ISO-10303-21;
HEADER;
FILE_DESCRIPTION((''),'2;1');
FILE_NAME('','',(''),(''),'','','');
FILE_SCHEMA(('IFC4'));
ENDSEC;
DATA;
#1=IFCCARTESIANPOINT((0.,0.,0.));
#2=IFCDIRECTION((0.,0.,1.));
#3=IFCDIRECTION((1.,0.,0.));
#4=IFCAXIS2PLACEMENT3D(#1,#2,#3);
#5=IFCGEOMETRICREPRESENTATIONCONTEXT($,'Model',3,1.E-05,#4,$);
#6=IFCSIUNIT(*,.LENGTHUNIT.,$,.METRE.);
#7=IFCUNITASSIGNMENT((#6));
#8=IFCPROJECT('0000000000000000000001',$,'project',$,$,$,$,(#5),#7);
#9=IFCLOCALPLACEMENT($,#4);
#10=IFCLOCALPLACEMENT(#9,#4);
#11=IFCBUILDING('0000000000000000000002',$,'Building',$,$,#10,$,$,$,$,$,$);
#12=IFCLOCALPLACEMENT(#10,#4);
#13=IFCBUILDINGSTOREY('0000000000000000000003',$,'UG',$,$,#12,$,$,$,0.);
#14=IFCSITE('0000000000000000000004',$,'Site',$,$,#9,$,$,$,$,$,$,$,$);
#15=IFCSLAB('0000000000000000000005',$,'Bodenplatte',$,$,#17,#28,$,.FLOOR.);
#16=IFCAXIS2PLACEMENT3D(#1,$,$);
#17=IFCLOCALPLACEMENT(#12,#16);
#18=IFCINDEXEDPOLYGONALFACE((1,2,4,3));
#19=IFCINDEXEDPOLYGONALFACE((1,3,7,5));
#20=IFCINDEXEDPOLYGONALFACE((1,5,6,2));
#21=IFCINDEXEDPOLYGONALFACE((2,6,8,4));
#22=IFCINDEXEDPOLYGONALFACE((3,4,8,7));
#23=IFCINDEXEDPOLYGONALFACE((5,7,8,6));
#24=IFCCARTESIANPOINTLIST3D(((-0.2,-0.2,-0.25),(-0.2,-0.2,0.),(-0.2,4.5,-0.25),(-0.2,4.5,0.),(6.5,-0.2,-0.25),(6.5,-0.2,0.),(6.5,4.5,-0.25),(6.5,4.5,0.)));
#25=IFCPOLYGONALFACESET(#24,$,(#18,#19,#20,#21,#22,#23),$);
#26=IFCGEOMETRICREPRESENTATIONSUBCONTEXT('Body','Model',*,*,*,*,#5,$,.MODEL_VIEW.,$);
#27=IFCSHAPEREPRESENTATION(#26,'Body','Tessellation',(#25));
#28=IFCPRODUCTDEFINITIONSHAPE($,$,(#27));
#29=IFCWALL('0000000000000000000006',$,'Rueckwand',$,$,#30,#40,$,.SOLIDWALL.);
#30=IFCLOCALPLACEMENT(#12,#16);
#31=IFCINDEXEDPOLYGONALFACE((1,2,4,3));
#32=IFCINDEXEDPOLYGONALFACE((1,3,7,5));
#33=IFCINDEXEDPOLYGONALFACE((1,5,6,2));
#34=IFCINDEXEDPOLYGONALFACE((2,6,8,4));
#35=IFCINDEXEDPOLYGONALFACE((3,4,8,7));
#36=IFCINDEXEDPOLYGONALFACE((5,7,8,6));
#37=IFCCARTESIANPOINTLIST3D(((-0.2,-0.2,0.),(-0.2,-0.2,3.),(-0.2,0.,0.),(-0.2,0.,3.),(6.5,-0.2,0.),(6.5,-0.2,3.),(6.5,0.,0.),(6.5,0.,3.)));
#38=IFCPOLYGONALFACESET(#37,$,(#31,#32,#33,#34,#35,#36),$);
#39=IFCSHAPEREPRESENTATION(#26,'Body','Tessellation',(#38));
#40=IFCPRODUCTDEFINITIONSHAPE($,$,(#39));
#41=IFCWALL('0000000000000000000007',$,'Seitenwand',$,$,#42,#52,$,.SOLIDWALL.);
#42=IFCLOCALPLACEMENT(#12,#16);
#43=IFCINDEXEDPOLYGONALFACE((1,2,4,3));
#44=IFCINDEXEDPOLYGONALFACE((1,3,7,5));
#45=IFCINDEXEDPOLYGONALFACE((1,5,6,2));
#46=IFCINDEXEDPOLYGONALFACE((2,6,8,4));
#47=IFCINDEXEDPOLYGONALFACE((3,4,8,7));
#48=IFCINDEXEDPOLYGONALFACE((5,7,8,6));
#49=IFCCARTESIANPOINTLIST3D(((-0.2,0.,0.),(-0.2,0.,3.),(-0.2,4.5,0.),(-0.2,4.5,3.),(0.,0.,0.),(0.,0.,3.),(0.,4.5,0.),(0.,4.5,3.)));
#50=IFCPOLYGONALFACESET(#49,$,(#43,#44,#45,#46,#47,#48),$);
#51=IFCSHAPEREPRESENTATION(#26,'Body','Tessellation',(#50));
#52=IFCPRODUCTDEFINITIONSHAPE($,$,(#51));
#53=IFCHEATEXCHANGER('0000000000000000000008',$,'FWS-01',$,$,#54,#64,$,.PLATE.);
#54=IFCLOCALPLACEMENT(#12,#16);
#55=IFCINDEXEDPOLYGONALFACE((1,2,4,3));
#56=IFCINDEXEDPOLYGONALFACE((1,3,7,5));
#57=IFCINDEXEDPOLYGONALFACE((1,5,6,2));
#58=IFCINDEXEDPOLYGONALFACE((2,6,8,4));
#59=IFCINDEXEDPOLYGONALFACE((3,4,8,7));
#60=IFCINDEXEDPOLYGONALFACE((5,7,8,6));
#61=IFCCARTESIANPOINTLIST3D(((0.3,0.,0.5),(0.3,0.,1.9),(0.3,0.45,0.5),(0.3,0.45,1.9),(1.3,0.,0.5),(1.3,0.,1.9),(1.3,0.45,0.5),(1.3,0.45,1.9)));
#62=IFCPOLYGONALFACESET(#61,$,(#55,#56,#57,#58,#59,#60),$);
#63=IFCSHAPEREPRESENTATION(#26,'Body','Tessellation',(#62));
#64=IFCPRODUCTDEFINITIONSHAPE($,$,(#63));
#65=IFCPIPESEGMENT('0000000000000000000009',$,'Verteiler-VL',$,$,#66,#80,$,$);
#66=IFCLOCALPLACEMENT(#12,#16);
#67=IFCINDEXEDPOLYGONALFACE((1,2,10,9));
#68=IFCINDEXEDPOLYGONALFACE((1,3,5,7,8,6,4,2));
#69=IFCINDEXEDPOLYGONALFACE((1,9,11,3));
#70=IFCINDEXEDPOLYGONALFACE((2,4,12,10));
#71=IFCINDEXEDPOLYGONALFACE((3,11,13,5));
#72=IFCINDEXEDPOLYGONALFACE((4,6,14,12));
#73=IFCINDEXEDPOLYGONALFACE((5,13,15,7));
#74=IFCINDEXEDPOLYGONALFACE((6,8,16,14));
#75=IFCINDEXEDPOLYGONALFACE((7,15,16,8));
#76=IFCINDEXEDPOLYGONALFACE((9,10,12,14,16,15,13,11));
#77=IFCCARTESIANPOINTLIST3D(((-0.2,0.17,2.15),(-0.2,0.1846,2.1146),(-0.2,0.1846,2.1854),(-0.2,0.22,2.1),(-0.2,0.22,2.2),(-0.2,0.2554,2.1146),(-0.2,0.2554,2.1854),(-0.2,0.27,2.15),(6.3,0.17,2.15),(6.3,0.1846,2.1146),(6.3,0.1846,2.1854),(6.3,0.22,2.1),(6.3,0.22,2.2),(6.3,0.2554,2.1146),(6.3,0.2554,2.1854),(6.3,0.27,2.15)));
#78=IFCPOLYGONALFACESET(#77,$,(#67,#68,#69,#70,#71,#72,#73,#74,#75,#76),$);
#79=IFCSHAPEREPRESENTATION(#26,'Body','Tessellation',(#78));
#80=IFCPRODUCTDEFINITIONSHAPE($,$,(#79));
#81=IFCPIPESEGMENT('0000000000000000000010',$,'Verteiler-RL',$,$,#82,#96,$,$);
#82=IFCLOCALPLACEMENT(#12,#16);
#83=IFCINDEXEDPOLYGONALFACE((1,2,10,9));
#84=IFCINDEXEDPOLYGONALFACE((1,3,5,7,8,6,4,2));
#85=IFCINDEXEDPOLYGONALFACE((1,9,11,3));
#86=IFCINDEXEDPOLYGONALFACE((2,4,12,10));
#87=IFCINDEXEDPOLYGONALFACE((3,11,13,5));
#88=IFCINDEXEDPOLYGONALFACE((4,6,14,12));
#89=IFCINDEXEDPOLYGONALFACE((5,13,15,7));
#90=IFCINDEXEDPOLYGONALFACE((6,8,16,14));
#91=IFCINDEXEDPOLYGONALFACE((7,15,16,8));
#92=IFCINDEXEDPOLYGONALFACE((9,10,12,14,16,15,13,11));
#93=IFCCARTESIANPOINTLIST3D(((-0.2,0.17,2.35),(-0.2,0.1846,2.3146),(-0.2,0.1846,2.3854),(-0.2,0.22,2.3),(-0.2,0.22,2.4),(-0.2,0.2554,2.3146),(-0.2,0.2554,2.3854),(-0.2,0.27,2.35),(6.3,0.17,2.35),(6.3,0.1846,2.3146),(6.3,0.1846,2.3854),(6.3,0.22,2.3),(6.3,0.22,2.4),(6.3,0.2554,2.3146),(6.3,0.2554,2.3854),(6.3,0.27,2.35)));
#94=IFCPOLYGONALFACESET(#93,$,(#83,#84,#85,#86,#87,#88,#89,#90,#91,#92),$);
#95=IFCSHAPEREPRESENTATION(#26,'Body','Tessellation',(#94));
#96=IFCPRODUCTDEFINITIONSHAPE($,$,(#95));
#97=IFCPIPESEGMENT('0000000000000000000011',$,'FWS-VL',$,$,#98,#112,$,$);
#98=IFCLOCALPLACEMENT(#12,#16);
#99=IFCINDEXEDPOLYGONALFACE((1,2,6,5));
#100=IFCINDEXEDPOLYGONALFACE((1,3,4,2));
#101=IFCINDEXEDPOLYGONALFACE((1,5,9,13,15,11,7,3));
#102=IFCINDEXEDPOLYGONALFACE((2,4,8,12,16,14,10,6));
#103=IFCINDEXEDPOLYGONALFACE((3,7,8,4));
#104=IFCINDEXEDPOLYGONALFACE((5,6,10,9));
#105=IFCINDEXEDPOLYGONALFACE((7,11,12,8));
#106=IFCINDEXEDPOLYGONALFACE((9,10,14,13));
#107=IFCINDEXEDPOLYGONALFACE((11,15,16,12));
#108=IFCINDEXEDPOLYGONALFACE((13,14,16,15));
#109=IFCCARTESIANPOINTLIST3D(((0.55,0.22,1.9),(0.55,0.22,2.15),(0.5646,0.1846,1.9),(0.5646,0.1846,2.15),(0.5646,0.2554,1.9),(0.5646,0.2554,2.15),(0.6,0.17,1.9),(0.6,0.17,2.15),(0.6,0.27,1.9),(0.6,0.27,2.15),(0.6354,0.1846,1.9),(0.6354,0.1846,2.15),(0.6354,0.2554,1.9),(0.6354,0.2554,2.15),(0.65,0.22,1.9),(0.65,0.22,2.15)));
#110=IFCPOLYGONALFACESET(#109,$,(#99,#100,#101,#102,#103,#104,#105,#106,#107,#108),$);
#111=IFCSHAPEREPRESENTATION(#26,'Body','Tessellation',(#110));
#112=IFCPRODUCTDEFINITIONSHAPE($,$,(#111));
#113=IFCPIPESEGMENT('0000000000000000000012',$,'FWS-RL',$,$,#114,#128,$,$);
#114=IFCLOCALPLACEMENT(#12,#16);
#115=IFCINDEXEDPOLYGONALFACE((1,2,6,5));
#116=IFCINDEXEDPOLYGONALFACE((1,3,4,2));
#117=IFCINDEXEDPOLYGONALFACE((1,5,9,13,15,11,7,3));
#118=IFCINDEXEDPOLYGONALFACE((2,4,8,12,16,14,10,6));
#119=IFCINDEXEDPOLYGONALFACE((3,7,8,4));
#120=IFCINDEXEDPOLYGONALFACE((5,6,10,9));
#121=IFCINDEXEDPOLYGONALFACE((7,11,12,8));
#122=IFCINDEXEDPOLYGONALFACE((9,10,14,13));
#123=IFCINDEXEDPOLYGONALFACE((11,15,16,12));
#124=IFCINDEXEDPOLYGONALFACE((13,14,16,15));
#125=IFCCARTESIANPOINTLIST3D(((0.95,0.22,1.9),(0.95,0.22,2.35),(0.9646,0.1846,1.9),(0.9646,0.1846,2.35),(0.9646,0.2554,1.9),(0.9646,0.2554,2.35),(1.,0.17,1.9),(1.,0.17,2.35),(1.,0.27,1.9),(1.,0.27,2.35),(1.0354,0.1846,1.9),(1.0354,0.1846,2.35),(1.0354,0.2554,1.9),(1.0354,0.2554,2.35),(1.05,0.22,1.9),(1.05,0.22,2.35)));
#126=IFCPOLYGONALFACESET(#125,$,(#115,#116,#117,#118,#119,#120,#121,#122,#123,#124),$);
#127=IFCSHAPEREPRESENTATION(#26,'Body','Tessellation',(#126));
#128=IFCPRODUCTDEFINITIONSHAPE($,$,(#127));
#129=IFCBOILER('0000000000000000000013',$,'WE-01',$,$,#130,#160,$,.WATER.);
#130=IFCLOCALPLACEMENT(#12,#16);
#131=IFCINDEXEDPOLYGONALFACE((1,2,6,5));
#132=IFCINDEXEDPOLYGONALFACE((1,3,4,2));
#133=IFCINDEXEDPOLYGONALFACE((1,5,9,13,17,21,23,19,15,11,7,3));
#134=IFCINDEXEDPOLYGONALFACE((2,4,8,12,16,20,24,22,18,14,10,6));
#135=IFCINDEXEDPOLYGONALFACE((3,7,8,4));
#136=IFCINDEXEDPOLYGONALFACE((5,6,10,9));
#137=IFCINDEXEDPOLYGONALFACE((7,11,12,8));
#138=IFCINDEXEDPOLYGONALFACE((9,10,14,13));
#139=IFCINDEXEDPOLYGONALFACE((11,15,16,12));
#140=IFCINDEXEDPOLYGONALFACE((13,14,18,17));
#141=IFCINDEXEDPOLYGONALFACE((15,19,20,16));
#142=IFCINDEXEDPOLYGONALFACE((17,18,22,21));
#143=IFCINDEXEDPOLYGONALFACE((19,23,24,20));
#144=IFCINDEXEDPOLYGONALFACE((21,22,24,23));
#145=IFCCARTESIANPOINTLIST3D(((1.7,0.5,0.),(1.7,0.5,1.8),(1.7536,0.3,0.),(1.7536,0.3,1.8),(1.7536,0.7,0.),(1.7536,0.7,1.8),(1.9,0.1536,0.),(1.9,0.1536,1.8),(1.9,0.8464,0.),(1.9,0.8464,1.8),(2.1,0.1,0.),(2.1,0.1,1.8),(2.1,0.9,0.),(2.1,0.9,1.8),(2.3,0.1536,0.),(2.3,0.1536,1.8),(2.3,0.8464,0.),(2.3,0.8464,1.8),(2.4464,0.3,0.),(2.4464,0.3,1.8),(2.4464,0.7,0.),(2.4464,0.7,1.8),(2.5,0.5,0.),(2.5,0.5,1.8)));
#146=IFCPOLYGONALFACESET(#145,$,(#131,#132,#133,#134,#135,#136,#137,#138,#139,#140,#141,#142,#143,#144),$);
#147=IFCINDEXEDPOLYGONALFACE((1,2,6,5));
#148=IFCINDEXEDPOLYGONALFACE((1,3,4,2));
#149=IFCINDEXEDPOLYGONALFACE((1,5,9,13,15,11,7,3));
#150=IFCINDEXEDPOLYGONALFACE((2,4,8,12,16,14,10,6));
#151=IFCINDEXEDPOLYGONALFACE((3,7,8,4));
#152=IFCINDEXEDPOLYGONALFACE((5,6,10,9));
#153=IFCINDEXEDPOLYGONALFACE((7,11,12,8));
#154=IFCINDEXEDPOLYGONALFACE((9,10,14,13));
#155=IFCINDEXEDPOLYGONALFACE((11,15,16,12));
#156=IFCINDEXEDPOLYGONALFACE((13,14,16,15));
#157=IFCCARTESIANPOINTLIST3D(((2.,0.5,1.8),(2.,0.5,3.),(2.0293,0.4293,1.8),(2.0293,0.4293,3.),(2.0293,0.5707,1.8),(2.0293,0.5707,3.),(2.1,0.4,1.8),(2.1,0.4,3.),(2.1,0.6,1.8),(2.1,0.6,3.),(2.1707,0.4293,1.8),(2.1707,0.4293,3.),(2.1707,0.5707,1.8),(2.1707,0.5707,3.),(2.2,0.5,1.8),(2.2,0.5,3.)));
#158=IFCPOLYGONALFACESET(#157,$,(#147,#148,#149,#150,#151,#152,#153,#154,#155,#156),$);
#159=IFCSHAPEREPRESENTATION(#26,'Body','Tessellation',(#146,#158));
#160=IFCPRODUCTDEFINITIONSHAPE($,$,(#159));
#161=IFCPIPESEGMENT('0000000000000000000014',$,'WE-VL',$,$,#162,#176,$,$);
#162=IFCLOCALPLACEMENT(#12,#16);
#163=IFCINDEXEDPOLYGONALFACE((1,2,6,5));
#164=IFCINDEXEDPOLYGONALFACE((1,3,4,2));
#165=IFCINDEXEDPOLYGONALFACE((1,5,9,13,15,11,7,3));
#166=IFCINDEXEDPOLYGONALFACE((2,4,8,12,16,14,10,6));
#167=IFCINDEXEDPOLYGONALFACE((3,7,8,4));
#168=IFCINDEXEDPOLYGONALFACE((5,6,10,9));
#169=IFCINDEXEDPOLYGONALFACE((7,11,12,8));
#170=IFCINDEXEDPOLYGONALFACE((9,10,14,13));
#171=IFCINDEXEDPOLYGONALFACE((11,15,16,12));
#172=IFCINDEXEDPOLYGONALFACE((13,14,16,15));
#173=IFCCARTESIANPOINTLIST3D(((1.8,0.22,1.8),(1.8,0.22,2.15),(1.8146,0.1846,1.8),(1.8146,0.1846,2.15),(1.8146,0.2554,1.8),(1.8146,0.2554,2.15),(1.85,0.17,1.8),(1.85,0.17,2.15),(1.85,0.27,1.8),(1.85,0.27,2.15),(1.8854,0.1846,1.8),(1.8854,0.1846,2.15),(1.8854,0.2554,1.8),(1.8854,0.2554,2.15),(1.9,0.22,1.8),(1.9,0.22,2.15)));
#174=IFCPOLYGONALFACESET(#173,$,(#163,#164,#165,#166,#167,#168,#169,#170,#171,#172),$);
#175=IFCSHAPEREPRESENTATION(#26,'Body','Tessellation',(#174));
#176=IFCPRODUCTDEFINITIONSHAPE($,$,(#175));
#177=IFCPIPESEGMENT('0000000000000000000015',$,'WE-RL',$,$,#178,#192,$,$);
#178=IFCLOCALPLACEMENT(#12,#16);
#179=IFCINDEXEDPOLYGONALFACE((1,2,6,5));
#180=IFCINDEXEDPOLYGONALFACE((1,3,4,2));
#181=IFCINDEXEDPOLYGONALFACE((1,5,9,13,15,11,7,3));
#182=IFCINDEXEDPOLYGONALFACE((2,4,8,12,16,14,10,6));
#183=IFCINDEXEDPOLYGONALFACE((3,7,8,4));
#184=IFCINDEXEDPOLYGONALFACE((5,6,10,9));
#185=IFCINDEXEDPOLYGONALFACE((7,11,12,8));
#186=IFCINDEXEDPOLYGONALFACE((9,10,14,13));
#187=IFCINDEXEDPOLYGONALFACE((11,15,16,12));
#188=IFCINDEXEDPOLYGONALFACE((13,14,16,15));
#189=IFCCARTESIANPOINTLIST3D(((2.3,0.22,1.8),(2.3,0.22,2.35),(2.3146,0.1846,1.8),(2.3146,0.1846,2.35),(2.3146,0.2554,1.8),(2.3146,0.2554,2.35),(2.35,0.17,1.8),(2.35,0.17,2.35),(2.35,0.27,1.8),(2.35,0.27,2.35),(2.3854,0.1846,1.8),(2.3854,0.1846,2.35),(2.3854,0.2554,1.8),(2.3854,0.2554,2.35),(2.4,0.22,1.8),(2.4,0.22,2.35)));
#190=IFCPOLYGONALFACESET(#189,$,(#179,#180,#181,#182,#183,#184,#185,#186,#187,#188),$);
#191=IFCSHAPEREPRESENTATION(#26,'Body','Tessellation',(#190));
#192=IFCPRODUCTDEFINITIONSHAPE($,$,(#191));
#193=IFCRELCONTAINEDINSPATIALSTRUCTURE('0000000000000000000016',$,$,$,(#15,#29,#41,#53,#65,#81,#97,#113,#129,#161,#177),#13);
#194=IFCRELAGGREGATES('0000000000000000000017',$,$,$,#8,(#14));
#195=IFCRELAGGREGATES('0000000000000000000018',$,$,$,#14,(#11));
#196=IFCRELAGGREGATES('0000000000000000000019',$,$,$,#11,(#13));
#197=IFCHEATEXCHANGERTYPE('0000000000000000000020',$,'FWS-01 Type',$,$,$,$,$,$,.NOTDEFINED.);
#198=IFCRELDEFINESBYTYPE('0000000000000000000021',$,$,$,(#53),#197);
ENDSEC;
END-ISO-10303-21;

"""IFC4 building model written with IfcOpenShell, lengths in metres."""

from ifc_helpers import new_model, si_unit, frame, origin_with_axes, place, context, subcontext, project, spatial, polyline, outline, extrude, type_object, element, save


model = new_model("IFC4")

# Units and contexts
model_context = context("Model", 3, precision=1e-05, world=origin_with_axes())
body_context = subcontext(model_context, "Body", "Model", "MODEL_VIEW")
ifc_project = project(units=[si_unit("LENGTHUNIT", "METRE")], contexts=[model_context])

# Site, building, storey
site_placement = place(None, origin_with_axes())
site = spatial("IfcSite", under=ifc_project, at=site_placement, Name="Site")
building_placement = place(site_placement, origin_with_axes())
building = spatial("IfcBuilding", under=site, at=building_placement, Name="Building")
storey_placement = place(building_placement, origin_with_axes())
storey = spatial("IfcBuildingStorey", under=building, at=storey_placement, Name="UG", Elevation=0.0)

# Slab
slab_placement = place(storey_placement, frame((0.0, 0.0, -0.25), z_axis=(0.0, 0.0, 1.0), x_axis=(1.0, 0.0, 0.0)))
element("IfcSlab", 1, at=slab_placement, inside=storey, Name="Bodenplatte", PredefinedType="FLOOR", context=body_context, shape_type="SweptSolid", body=[
    extrude(outline(polyline([(-0.2, -0.2, 0.0), (6.5, -0.2, 0.0), (6.5, 4.5, 0.0), (-0.2, 4.5, 0.0), (-0.2, -0.2, 0.0)])), origin_with_axes(), (0.0, 0.0, 1.0), 0.25),
])

# Walls
wall_1_placement = place(storey_placement, frame((-0.2, -0.2, 0.0), z_axis=(0.0, 0.0, 1.0), x_axis=(1.0, 0.0, 0.0)))
element("IfcWall", 2, at=wall_1_placement, inside=storey, Name="Rueckwand", PredefinedType="SOLIDWALL", context=body_context, shape_type="SweptSolid", body=[
    extrude(outline(polyline([(0.0, 0.0, 0.0), (6.7, 0.0, 0.0), (6.7, 0.2, 0.0), (0.0, 0.2, 0.0), (0.0, 0.0, 0.0)])), origin_with_axes(), (0.0, 0.0, 1.0), 3.0),
])
wall_2_placement = place(storey_placement, frame((0.0, 0.0, 0.0), z_axis=(0.0, 0.0, 1.0), x_axis=(0.0, 1.0, 0.0)))
element("IfcWall", 3, at=wall_2_placement, inside=storey, Name="Seitenwand", PredefinedType="SOLIDWALL", context=body_context, shape_type="SweptSolid", body=[
    extrude(outline(polyline([(0.0, 0.0, 0.0), (4.5, 0.0, 0.0), (4.5, 0.2, 0.0), (0.0, 0.2, 0.0), (0.0, 0.0, 0.0)])), origin_with_axes(), (0.0, 0.0, 1.0), 3.0),
])

# Heat exchanger
heat_exchanger_type = type_object("IfcHeatExchangerType", Name="FWS-01 Type", PredefinedType="NOTDEFINED")
heat_exchanger_placement = place(storey_placement, origin_with_axes())
element("IfcHeatExchanger", 4, at=heat_exchanger_placement, inside=storey, type_object=heat_exchanger_type, Name="FWS-01", PredefinedType="PLATE", context=body_context, shape_type="SweptSolid", body=[
    extrude(outline(polyline([(0.3, 0.0, 0.0), (1.3, 0.0, 0.0), (1.3, 0.45, 0.0), (0.3, 0.45, 0.0), (0.3, 0.0, 0.0)])), frame((0.0, 0.0, 0.5), z_axis=(0.0, 0.0, 1.0), x_axis=(1.0, 0.0, 0.0)), (0.0, 0.0, 1.0), 1.4),
])

# Pipe segments
pipe_segment_1_placement = place(storey_placement, origin_with_axes())
element("IfcPipeSegment", 5, at=pipe_segment_1_placement, inside=storey, Name="Verteiler-VL", context=body_context, shape_type="SweptSolid", body=[
    extrude(outline(polyline([(0.05, 0.0, 0.0), (0.0354, 0.0354, 0.0), (0.0, 0.05, 0.0), (-0.0354, 0.0354, 0.0), (-0.05, 0.0, 0.0), (-0.0354, -0.0354, 0.0), (0.0, -0.05, 0.0), (0.0354, -0.0354, 0.0), (0.05, 0.0, 0.0)])), frame((-0.2, 0.22, 2.15), z_axis=(1.0, 0.0, 0.0), x_axis=(0.0, 1.0, 0.0)), (0.0, 0.0, 1.0), 6.5),
])
pipe_segment_2_placement = place(storey_placement, origin_with_axes())
element("IfcPipeSegment", 6, at=pipe_segment_2_placement, inside=storey, Name="Verteiler-RL", context=body_context, shape_type="SweptSolid", body=[
    extrude(outline(polyline([(0.05, 0.0, 0.0), (0.0354, 0.0354, 0.0), (0.0, 0.05, 0.0), (-0.0354, 0.0354, 0.0), (-0.05, 0.0, 0.0), (-0.0354, -0.0354, 0.0), (0.0, -0.05, 0.0), (0.0354, -0.0354, 0.0), (0.05, 0.0, 0.0)])), frame((-0.2, 0.22, 2.35), z_axis=(1.0, 0.0, 0.0), x_axis=(0.0, 1.0, 0.0)), (0.0, 0.0, 1.0), 6.5),
])
pipe_segment_3_placement = place(storey_placement, origin_with_axes())
element("IfcPipeSegment", 7, at=pipe_segment_3_placement, inside=storey, Name="FWS-VL", context=body_context, shape_type="SweptSolid", body=[
    extrude(outline(polyline([(0.05, 0.0, 0.0), (0.0354, 0.0354, 0.0), (0.0, 0.05, 0.0), (-0.0354, 0.0354, 0.0), (-0.05, 0.0, 0.0), (-0.0354, -0.0354, 0.0), (0.0, -0.05, 0.0), (0.0354, -0.0354, 0.0), (0.05, 0.0, 0.0)])), frame((0.6, 0.22, 1.9), z_axis=(0.0, 0.0, 1.0), x_axis=(1.0, 0.0, 0.0)), (0.0, 0.0, 1.0), 0.25),
])
pipe_segment_4_placement = place(storey_placement, origin_with_axes())
element("IfcPipeSegment", 8, at=pipe_segment_4_placement, inside=storey, Name="FWS-RL", context=body_context, shape_type="SweptSolid", body=[
    extrude(outline(polyline([(0.05, 0.0, 0.0), (0.0354, 0.0354, 0.0), (0.0, 0.05, 0.0), (-0.0354, 0.0354, 0.0), (-0.05, 0.0, 0.0), (-0.0354, -0.0354, 0.0), (0.0, -0.05, 0.0), (0.0354, -0.0354, 0.0), (0.05, 0.0, 0.0)])), frame((1.0, 0.22, 1.9), z_axis=(0.0, 0.0, 1.0), x_axis=(1.0, 0.0, 0.0)), (0.0, 0.0, 1.0), 0.45),
])

# Boiler
boiler_placement = place(storey_placement, origin_with_axes())
element("IfcBoiler", 9, at=boiler_placement, inside=storey, Name="WE-01", PredefinedType="WATER", context=body_context, shape_type="SweptSolid", body=[
    extrude(outline(polyline([(0.4, 0.0, 0.0), (0.3464, 0.2, 0.0), (0.2, 0.3464, 0.0), (0.0, 0.4, 0.0), (-0.2, 0.3464, 0.0), (-0.3464, 0.2, 0.0), (-0.4, 0.0, 0.0), (-0.3464, -0.2, 0.0), (-0.2, -0.3464, 0.0), (0.0, -0.4, 0.0), (0.2, -0.3464, 0.0), (0.3464, -0.2, 0.0), (0.4, 0.0, 0.0)])), frame((2.1, 0.5, 0.0), z_axis=(0.0, 0.0, 1.0), x_axis=(1.0, 0.0, 0.0)), (0.0, 0.0, 1.0), 1.8),
    extrude(outline(polyline([(0.1, 0.0, 0.0), (0.0707, 0.0707, 0.0), (0.0, 0.1, 0.0), (-0.0707, 0.0707, 0.0), (-0.1, 0.0, 0.0), (-0.0707, -0.0707, 0.0), (0.0, -0.1, 0.0), (0.0707, -0.0707, 0.0), (0.1, 0.0, 0.0)])), frame((2.1, 0.5, 1.8), z_axis=(0.0, 0.0, 1.0), x_axis=(1.0, 0.0, 0.0)), (0.0, 0.0, 1.0), 1.2),
])

# Pipe segments
pipe_segment_5_placement = place(storey_placement, origin_with_axes())
element("IfcPipeSegment", 10, at=pipe_segment_5_placement, inside=storey, Name="WE-VL", context=body_context, shape_type="SweptSolid", body=[
    extrude(outline(polyline([(0.05, 0.0, 0.0), (0.0354, 0.0354, 0.0), (0.0, 0.05, 0.0), (-0.0354, 0.0354, 0.0), (-0.05, 0.0, 0.0), (-0.0354, -0.0354, 0.0), (0.0, -0.05, 0.0), (0.0354, -0.0354, 0.0), (0.05, 0.0, 0.0)])), frame((1.85, 0.22, 1.8), z_axis=(0.0, 0.0, 1.0), x_axis=(1.0, 0.0, 0.0)), (0.0, 0.0, 1.0), 0.35),
])
pipe_segment_6_placement = place(storey_placement, origin_with_axes())
element("IfcPipeSegment", 11, at=pipe_segment_6_placement, inside=storey, Name="WE-RL", context=body_context, shape_type="SweptSolid", body=[
    extrude(outline(polyline([(0.05, 0.0, 0.0), (0.0354, 0.0354, 0.0), (0.0, 0.05, 0.0), (-0.0354, 0.0354, 0.0), (-0.05, 0.0, 0.0), (-0.0354, -0.0354, 0.0), (0.0, -0.05, 0.0), (0.0354, -0.0354, 0.0), (0.05, 0.0, 0.0)])), frame((2.35, 0.22, 1.8), z_axis=(0.0, 0.0, 1.0), x_axis=(1.0, 0.0, 0.0)), (0.0, 0.0, 1.0), 0.55),
])

save(model, "model.ifc")
